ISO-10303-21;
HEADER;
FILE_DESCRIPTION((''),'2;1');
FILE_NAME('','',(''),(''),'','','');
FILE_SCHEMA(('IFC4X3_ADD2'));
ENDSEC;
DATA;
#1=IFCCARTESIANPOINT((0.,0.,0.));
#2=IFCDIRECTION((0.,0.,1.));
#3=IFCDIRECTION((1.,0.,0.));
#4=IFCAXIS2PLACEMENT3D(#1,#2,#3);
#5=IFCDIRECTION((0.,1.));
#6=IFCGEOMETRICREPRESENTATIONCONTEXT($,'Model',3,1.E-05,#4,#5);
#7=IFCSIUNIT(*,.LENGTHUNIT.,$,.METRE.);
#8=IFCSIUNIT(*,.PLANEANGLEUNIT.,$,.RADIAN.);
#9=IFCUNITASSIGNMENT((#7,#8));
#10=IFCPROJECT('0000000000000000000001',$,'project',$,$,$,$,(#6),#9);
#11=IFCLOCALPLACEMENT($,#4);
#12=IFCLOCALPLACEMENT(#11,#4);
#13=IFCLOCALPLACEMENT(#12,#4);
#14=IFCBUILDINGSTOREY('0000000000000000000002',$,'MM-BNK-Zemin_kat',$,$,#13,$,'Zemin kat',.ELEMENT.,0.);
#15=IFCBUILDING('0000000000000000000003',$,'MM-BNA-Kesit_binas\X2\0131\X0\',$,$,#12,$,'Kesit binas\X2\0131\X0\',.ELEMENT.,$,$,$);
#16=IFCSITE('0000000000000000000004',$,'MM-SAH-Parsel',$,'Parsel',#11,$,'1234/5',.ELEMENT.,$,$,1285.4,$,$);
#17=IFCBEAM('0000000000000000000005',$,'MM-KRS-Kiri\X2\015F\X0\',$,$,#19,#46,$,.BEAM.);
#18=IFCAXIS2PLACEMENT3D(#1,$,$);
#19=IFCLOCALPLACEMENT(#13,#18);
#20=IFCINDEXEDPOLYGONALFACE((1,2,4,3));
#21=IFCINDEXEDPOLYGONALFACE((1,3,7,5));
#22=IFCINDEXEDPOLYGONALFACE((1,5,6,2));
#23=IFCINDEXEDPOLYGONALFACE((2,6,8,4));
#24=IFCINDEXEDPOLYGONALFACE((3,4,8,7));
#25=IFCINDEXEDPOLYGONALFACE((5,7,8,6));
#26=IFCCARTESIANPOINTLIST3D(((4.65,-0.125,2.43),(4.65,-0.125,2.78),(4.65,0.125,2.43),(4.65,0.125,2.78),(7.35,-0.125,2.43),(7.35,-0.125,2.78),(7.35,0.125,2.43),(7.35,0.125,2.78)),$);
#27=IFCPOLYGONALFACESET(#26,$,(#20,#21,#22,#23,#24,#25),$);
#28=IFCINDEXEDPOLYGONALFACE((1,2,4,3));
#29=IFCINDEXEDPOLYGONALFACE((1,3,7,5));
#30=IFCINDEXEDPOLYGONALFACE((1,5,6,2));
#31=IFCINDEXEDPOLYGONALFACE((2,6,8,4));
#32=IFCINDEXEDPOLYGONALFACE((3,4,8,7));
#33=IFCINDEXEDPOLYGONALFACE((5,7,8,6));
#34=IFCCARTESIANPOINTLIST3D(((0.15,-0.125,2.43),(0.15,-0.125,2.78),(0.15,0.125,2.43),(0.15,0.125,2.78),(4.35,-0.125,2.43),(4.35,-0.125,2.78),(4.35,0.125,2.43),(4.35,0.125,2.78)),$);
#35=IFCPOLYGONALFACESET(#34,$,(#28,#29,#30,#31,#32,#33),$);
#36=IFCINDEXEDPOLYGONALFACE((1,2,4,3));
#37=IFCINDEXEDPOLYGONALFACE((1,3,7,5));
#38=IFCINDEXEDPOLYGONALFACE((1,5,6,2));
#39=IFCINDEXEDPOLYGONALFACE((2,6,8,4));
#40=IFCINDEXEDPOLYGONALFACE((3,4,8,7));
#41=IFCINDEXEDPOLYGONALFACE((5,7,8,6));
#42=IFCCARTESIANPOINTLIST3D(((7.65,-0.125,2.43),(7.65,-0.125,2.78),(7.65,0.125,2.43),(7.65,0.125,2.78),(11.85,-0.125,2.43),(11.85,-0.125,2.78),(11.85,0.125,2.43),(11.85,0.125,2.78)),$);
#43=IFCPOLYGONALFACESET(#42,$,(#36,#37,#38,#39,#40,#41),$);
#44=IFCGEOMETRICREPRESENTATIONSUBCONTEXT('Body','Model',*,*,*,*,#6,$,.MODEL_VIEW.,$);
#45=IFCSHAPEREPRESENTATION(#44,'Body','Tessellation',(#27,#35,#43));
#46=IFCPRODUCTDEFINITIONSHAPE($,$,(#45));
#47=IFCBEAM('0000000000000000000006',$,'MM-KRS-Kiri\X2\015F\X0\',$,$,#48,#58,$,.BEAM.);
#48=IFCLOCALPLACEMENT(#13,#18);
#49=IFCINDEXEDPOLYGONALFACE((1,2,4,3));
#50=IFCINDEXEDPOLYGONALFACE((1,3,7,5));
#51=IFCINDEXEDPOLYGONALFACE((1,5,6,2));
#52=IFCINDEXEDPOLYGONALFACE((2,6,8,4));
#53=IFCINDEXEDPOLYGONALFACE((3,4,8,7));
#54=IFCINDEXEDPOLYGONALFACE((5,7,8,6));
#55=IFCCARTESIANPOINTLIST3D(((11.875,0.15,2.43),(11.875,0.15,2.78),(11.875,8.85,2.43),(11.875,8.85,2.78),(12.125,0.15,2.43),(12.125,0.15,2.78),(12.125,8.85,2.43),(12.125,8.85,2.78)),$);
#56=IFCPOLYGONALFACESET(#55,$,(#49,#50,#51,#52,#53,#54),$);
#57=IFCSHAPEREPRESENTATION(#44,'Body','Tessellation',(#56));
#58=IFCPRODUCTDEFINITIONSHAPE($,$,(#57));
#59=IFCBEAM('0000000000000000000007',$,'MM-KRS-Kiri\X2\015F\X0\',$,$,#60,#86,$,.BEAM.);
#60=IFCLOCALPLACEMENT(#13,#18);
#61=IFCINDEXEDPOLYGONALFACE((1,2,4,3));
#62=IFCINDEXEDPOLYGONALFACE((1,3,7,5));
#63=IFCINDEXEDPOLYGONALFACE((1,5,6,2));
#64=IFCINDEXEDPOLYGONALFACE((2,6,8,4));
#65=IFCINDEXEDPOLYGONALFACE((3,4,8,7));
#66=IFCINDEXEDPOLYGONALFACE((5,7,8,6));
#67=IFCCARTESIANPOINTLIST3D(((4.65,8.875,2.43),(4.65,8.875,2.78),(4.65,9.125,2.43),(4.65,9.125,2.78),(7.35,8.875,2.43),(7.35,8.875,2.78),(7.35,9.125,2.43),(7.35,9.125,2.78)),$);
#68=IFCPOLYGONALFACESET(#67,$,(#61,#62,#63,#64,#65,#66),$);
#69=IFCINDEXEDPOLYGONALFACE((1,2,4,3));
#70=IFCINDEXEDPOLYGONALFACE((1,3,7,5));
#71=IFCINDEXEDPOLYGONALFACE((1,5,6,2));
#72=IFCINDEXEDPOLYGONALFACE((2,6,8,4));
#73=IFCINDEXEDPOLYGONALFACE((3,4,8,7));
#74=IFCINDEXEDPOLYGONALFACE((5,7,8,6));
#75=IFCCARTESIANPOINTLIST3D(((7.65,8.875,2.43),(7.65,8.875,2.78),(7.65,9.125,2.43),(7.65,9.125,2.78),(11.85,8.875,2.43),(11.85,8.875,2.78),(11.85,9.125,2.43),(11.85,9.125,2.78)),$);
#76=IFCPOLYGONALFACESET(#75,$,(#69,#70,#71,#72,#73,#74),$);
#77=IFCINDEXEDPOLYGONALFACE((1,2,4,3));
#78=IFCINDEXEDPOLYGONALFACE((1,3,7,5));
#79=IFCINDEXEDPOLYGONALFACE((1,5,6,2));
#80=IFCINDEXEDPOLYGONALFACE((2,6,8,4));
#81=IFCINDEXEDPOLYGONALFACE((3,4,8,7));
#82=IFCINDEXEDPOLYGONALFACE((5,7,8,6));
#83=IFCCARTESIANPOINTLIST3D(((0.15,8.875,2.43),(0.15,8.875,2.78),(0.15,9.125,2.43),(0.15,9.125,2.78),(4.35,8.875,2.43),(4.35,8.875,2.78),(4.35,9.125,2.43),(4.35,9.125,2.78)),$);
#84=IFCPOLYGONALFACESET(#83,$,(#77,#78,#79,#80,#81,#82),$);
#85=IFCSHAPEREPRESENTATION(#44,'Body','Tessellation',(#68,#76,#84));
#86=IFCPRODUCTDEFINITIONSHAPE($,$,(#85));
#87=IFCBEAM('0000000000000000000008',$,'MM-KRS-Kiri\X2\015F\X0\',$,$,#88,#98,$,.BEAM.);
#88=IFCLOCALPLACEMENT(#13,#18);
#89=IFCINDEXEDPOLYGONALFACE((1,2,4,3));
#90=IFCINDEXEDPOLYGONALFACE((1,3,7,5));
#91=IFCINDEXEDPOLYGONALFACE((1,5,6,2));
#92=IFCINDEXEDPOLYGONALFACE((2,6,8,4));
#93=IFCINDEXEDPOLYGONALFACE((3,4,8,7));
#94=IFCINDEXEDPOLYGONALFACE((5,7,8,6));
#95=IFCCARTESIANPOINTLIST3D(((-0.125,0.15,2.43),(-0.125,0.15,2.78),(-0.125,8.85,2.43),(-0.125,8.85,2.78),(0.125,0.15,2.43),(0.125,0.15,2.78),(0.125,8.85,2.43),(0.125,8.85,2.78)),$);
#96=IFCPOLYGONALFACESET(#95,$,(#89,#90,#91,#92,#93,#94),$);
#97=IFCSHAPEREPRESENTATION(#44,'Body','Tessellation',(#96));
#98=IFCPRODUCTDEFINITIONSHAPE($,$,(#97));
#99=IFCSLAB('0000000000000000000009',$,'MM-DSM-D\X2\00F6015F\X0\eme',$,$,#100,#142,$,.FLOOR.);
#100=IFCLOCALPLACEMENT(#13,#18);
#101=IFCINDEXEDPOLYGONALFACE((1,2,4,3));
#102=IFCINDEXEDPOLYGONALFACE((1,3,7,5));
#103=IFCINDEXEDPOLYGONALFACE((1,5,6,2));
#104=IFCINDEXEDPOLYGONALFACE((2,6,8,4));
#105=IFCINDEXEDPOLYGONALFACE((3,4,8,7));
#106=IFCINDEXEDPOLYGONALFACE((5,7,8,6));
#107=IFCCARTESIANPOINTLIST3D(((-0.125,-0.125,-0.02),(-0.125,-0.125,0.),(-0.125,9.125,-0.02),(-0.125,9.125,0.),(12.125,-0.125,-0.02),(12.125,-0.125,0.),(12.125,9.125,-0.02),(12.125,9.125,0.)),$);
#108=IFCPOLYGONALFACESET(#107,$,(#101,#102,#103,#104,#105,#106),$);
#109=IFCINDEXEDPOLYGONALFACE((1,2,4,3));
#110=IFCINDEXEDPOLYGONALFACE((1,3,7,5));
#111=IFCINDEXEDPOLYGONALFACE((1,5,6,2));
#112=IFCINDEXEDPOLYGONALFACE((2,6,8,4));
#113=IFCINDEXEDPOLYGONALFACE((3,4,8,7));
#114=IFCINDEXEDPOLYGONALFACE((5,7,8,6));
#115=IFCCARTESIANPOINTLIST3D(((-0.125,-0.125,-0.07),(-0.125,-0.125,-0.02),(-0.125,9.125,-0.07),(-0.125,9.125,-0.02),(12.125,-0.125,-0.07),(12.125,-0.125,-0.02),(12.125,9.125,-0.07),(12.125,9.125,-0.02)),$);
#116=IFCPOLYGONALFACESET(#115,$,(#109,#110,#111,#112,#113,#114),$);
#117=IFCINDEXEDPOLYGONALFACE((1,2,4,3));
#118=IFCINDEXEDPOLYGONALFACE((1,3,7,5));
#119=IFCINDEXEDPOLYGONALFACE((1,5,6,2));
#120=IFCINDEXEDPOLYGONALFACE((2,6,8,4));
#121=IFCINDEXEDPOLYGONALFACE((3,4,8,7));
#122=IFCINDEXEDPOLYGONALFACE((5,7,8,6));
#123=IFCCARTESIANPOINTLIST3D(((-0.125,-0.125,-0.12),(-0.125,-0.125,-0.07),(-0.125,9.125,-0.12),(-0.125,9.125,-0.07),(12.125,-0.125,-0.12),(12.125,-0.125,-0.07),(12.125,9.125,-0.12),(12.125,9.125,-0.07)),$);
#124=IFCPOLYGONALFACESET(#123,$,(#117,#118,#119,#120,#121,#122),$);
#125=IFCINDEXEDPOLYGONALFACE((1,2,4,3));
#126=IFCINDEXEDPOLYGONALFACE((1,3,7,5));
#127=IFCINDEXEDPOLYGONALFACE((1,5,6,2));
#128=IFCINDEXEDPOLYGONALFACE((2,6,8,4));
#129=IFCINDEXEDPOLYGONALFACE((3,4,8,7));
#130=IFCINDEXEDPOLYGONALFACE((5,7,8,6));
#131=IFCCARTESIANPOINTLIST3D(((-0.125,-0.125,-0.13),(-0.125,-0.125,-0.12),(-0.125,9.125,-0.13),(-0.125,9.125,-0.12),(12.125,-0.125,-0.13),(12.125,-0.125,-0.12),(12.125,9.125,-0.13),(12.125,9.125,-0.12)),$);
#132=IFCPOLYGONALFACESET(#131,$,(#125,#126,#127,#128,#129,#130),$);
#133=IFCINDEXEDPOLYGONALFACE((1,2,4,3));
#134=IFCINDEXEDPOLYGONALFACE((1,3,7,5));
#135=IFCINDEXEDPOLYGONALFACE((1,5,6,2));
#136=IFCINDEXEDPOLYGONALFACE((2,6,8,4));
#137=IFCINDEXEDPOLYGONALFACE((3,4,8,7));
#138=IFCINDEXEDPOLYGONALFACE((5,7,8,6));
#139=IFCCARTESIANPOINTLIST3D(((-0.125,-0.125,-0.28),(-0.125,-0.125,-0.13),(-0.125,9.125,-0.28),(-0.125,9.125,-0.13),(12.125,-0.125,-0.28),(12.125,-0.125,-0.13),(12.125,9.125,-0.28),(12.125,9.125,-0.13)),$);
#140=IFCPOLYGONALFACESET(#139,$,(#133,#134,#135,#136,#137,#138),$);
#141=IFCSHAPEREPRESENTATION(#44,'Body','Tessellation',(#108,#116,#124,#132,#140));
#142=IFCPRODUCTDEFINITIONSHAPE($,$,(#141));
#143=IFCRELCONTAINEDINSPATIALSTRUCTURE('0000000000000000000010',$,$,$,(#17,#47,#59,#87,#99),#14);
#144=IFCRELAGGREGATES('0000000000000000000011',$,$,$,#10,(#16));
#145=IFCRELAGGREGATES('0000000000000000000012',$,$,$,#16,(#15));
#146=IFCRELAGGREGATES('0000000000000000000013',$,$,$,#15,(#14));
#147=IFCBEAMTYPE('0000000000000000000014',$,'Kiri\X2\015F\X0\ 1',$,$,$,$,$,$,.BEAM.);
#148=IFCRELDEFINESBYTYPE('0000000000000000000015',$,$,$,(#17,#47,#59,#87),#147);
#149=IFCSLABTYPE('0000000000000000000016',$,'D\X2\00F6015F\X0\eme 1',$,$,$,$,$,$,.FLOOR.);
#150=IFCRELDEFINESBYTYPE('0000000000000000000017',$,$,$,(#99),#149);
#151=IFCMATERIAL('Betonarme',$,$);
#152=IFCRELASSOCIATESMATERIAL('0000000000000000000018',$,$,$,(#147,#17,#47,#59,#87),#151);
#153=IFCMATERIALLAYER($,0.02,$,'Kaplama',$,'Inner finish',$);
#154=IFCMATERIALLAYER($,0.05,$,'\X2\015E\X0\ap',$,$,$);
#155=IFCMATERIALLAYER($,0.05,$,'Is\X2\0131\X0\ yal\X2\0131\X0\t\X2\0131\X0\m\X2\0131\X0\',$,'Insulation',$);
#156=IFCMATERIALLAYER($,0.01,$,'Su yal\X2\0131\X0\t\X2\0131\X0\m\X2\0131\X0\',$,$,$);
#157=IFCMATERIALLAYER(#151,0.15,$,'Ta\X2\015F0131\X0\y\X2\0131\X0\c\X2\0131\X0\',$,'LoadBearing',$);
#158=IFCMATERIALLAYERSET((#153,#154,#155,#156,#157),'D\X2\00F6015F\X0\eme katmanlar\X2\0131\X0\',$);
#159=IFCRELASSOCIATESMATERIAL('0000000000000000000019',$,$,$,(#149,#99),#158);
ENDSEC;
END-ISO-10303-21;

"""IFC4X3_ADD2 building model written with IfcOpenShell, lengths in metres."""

from ifc_helpers import new_model, si_unit, direction, frame, origin_with_axes, place, context, subcontext, project, spatial, polyline, rectangle, outline, extrude, material, layer, layer_set, layer_usage, material_profile, profile_set, type_object, element, save


model = new_model("IFC4X3_ADD2")

# Units and contexts
model_context = context("Model", 3, precision=1e-05, world=origin_with_axes(), true_north=direction((0.0, 1.0)))
body_context = subcontext(model_context, "Body", "Model", "MODEL_VIEW")
ifc_project = project(units=[si_unit("LENGTHUNIT", "METRE"), si_unit("PLANEANGLEUNIT", "RADIAN")], contexts=[model_context])

# Site, building, storey
site_placement = place(None, origin_with_axes())
site = spatial("IfcSite", under=ifc_project, at=site_placement, Name="MM-SAH-Parsel", ObjectType="Parsel", LongName="1234/5", CompositionType="ELEMENT", RefElevation=1285.4)
building_placement = place(site_placement, origin_with_axes())
building = spatial("IfcBuilding", under=site, at=building_placement, Name="MM-BNA-Kesit_binası", LongName="Kesit binası", CompositionType="ELEMENT")
storey_placement = place(building_placement, origin_with_axes())
storey = spatial("IfcBuildingStorey", under=building, at=storey_placement, Name="MM-BNK-Zemin_kat", LongName="Zemin kat", CompositionType="ELEMENT", Elevation=0.0)

# Shared definitions
ifc_material_1 = material(Name="Betonarme")

# Beams
ifc_material_profile_1 = material_profile(ifc_material_1, rectangle(XDim=0.25, YDim=0.5), Category="LoadBearing")
ifc_profile_set_1 = profile_set([ifc_material_profile_1], Name="Kiriş 1")
beam_type = type_object("IfcBeamType", Name="Kiriş 1", PredefinedType="BEAM", material=ifc_profile_set_1)
beam_1_placement = place(storey_placement, origin_with_axes())
element("IfcBeam", 1, at=beam_1_placement, inside=storey, type_object=beam_type, material=ifc_material_1, Name="MM-KRS-Kiriş", PredefinedType="BEAM", context=body_context, shape_type="SweptSolid", body=[
    extrude(outline(polyline([(4.65, -0.125), (7.35, -0.125), (7.35, 0.125), (4.65, 0.125), (4.65, -0.125)])), frame((0.0, 0.0, 2.43)), (0.0, 0.0, 1.0), 0.35),
    extrude(outline(polyline([(0.15, -0.125), (4.35, -0.125), (4.35, 0.125), (0.15, 0.125), (0.15, -0.125)])), frame((0.0, 0.0, 2.43)), (0.0, 0.0, 1.0), 0.35),
    extrude(outline(polyline([(7.65, -0.125), (11.85, -0.125), (11.85, 0.125), (7.65, 0.125), (7.65, -0.125)])), frame((0.0, 0.0, 2.43)), (0.0, 0.0, 1.0), 0.35),
])
beam_2_placement = place(storey_placement, origin_with_axes())
element("IfcBeam", 2, at=beam_2_placement, inside=storey, type_object=beam_type, material=ifc_material_1, Name="MM-KRS-Kiriş", PredefinedType="BEAM", context=body_context, shape_type="SweptSolid", body=[
    extrude(outline(polyline([(12.125, 0.15), (12.125, 8.85), (11.875, 8.85), (11.875, 0.15), (12.125, 0.15)])), frame((0.0, 0.0, 2.43)), (0.0, 0.0, 1.0), 0.35),
])
beam_3_placement = place(storey_placement, origin_with_axes())
element("IfcBeam", 3, at=beam_3_placement, inside=storey, type_object=beam_type, material=ifc_material_1, Name="MM-KRS-Kiriş", PredefinedType="BEAM", context=body_context, shape_type="SweptSolid", body=[
    extrude(outline(polyline([(7.35, 9.125), (4.65, 9.125), (4.65, 8.875), (7.35, 8.875), (7.35, 9.125)])), frame((0.0, 0.0, 2.43)), (0.0, 0.0, 1.0), 0.35),
    extrude(outline(polyline([(11.85, 9.125), (7.65, 9.125), (7.65, 8.875), (11.85, 8.875), (11.85, 9.125)])), frame((0.0, 0.0, 2.43)), (0.0, 0.0, 1.0), 0.35),
    extrude(outline(polyline([(4.35, 9.125), (0.15, 9.125), (0.15, 8.875), (4.35, 8.875), (4.35, 9.125)])), frame((0.0, 0.0, 2.43)), (0.0, 0.0, 1.0), 0.35),
])
beam_4_placement = place(storey_placement, origin_with_axes())
element("IfcBeam", 4, at=beam_4_placement, inside=storey, type_object=beam_type, material=ifc_material_1, Name="MM-KRS-Kiriş", PredefinedType="BEAM", context=body_context, shape_type="SweptSolid", body=[
    extrude(outline(polyline([(-0.125, 8.85), (-0.125, 0.15), (0.125, 0.15), (0.125, 8.85), (-0.125, 8.85)])), frame((0.0, 0.0, 2.43)), (0.0, 0.0, 1.0), 0.35),
])

# Slab
ifc_layer_1 = layer(None, 0.02, Name="Kaplama", Category="Inner finish")
ifc_layer_2 = layer(None, 0.05, Name="Şap")
ifc_layer_3 = layer(None, 0.05, Name="Isı yalıtımı", Category="Insulation")
ifc_layer_4 = layer(None, 0.01, Name="Su yalıtımı")
ifc_layer_5 = layer(ifc_material_1, 0.15, Name="Taşıyıcı", Category="LoadBearing")
ifc_layer_set_1 = layer_set([ifc_layer_1, ifc_layer_2, ifc_layer_3, ifc_layer_4, ifc_layer_5], Name="Döşeme katmanları")
ifc_layer_usage = layer_usage(ifc_layer_set_1, "AXIS3", "NEGATIVE", 0.0)
slab_type = type_object("IfcSlabType", Name="Döşeme 1", PredefinedType="FLOOR", material=ifc_layer_set_1)
slab_placement = place(storey_placement, origin_with_axes())
element("IfcSlab", 5, at=slab_placement, inside=storey, type_object=slab_type, material=ifc_layer_usage, Name="MM-DSM-Döşeme", PredefinedType="FLOOR", context=body_context, shape_type="SweptSolid", body=[
    extrude(outline(polyline([(-0.125, -0.125), (12.125, -0.125), (12.125, 9.125), (-0.125, 9.125), (-0.125, -0.125)])), frame((0.0, 0.0, -0.02)), (0.0, 0.0, 1.0), 0.02),
    extrude(outline(polyline([(-0.125, -0.125), (12.125, -0.125), (12.125, 9.125), (-0.125, 9.125), (-0.125, -0.125)])), frame((0.0, 0.0, -0.07)), (0.0, 0.0, 1.0), 0.05),
    extrude(outline(polyline([(-0.125, -0.125), (12.125, -0.125), (12.125, 9.125), (-0.125, 9.125), (-0.125, -0.125)])), frame((0.0, 0.0, -0.12)), (0.0, 0.0, 1.0), 0.05),
    extrude(outline(polyline([(-0.125, -0.125), (12.125, -0.125), (12.125, 9.125), (-0.125, 9.125), (-0.125, -0.125)])), frame((0.0, 0.0, -0.13)), (0.0, 0.0, 1.0), 0.01),
    extrude(outline(polyline([(-0.125, -0.125), (12.125, -0.125), (12.125, 9.125), (-0.125, 9.125), (-0.125, -0.125)])), frame((0.0, 0.0, -0.28)), (0.0, 0.0, 1.0), 0.15),
])

save(model, "model.ifc")
